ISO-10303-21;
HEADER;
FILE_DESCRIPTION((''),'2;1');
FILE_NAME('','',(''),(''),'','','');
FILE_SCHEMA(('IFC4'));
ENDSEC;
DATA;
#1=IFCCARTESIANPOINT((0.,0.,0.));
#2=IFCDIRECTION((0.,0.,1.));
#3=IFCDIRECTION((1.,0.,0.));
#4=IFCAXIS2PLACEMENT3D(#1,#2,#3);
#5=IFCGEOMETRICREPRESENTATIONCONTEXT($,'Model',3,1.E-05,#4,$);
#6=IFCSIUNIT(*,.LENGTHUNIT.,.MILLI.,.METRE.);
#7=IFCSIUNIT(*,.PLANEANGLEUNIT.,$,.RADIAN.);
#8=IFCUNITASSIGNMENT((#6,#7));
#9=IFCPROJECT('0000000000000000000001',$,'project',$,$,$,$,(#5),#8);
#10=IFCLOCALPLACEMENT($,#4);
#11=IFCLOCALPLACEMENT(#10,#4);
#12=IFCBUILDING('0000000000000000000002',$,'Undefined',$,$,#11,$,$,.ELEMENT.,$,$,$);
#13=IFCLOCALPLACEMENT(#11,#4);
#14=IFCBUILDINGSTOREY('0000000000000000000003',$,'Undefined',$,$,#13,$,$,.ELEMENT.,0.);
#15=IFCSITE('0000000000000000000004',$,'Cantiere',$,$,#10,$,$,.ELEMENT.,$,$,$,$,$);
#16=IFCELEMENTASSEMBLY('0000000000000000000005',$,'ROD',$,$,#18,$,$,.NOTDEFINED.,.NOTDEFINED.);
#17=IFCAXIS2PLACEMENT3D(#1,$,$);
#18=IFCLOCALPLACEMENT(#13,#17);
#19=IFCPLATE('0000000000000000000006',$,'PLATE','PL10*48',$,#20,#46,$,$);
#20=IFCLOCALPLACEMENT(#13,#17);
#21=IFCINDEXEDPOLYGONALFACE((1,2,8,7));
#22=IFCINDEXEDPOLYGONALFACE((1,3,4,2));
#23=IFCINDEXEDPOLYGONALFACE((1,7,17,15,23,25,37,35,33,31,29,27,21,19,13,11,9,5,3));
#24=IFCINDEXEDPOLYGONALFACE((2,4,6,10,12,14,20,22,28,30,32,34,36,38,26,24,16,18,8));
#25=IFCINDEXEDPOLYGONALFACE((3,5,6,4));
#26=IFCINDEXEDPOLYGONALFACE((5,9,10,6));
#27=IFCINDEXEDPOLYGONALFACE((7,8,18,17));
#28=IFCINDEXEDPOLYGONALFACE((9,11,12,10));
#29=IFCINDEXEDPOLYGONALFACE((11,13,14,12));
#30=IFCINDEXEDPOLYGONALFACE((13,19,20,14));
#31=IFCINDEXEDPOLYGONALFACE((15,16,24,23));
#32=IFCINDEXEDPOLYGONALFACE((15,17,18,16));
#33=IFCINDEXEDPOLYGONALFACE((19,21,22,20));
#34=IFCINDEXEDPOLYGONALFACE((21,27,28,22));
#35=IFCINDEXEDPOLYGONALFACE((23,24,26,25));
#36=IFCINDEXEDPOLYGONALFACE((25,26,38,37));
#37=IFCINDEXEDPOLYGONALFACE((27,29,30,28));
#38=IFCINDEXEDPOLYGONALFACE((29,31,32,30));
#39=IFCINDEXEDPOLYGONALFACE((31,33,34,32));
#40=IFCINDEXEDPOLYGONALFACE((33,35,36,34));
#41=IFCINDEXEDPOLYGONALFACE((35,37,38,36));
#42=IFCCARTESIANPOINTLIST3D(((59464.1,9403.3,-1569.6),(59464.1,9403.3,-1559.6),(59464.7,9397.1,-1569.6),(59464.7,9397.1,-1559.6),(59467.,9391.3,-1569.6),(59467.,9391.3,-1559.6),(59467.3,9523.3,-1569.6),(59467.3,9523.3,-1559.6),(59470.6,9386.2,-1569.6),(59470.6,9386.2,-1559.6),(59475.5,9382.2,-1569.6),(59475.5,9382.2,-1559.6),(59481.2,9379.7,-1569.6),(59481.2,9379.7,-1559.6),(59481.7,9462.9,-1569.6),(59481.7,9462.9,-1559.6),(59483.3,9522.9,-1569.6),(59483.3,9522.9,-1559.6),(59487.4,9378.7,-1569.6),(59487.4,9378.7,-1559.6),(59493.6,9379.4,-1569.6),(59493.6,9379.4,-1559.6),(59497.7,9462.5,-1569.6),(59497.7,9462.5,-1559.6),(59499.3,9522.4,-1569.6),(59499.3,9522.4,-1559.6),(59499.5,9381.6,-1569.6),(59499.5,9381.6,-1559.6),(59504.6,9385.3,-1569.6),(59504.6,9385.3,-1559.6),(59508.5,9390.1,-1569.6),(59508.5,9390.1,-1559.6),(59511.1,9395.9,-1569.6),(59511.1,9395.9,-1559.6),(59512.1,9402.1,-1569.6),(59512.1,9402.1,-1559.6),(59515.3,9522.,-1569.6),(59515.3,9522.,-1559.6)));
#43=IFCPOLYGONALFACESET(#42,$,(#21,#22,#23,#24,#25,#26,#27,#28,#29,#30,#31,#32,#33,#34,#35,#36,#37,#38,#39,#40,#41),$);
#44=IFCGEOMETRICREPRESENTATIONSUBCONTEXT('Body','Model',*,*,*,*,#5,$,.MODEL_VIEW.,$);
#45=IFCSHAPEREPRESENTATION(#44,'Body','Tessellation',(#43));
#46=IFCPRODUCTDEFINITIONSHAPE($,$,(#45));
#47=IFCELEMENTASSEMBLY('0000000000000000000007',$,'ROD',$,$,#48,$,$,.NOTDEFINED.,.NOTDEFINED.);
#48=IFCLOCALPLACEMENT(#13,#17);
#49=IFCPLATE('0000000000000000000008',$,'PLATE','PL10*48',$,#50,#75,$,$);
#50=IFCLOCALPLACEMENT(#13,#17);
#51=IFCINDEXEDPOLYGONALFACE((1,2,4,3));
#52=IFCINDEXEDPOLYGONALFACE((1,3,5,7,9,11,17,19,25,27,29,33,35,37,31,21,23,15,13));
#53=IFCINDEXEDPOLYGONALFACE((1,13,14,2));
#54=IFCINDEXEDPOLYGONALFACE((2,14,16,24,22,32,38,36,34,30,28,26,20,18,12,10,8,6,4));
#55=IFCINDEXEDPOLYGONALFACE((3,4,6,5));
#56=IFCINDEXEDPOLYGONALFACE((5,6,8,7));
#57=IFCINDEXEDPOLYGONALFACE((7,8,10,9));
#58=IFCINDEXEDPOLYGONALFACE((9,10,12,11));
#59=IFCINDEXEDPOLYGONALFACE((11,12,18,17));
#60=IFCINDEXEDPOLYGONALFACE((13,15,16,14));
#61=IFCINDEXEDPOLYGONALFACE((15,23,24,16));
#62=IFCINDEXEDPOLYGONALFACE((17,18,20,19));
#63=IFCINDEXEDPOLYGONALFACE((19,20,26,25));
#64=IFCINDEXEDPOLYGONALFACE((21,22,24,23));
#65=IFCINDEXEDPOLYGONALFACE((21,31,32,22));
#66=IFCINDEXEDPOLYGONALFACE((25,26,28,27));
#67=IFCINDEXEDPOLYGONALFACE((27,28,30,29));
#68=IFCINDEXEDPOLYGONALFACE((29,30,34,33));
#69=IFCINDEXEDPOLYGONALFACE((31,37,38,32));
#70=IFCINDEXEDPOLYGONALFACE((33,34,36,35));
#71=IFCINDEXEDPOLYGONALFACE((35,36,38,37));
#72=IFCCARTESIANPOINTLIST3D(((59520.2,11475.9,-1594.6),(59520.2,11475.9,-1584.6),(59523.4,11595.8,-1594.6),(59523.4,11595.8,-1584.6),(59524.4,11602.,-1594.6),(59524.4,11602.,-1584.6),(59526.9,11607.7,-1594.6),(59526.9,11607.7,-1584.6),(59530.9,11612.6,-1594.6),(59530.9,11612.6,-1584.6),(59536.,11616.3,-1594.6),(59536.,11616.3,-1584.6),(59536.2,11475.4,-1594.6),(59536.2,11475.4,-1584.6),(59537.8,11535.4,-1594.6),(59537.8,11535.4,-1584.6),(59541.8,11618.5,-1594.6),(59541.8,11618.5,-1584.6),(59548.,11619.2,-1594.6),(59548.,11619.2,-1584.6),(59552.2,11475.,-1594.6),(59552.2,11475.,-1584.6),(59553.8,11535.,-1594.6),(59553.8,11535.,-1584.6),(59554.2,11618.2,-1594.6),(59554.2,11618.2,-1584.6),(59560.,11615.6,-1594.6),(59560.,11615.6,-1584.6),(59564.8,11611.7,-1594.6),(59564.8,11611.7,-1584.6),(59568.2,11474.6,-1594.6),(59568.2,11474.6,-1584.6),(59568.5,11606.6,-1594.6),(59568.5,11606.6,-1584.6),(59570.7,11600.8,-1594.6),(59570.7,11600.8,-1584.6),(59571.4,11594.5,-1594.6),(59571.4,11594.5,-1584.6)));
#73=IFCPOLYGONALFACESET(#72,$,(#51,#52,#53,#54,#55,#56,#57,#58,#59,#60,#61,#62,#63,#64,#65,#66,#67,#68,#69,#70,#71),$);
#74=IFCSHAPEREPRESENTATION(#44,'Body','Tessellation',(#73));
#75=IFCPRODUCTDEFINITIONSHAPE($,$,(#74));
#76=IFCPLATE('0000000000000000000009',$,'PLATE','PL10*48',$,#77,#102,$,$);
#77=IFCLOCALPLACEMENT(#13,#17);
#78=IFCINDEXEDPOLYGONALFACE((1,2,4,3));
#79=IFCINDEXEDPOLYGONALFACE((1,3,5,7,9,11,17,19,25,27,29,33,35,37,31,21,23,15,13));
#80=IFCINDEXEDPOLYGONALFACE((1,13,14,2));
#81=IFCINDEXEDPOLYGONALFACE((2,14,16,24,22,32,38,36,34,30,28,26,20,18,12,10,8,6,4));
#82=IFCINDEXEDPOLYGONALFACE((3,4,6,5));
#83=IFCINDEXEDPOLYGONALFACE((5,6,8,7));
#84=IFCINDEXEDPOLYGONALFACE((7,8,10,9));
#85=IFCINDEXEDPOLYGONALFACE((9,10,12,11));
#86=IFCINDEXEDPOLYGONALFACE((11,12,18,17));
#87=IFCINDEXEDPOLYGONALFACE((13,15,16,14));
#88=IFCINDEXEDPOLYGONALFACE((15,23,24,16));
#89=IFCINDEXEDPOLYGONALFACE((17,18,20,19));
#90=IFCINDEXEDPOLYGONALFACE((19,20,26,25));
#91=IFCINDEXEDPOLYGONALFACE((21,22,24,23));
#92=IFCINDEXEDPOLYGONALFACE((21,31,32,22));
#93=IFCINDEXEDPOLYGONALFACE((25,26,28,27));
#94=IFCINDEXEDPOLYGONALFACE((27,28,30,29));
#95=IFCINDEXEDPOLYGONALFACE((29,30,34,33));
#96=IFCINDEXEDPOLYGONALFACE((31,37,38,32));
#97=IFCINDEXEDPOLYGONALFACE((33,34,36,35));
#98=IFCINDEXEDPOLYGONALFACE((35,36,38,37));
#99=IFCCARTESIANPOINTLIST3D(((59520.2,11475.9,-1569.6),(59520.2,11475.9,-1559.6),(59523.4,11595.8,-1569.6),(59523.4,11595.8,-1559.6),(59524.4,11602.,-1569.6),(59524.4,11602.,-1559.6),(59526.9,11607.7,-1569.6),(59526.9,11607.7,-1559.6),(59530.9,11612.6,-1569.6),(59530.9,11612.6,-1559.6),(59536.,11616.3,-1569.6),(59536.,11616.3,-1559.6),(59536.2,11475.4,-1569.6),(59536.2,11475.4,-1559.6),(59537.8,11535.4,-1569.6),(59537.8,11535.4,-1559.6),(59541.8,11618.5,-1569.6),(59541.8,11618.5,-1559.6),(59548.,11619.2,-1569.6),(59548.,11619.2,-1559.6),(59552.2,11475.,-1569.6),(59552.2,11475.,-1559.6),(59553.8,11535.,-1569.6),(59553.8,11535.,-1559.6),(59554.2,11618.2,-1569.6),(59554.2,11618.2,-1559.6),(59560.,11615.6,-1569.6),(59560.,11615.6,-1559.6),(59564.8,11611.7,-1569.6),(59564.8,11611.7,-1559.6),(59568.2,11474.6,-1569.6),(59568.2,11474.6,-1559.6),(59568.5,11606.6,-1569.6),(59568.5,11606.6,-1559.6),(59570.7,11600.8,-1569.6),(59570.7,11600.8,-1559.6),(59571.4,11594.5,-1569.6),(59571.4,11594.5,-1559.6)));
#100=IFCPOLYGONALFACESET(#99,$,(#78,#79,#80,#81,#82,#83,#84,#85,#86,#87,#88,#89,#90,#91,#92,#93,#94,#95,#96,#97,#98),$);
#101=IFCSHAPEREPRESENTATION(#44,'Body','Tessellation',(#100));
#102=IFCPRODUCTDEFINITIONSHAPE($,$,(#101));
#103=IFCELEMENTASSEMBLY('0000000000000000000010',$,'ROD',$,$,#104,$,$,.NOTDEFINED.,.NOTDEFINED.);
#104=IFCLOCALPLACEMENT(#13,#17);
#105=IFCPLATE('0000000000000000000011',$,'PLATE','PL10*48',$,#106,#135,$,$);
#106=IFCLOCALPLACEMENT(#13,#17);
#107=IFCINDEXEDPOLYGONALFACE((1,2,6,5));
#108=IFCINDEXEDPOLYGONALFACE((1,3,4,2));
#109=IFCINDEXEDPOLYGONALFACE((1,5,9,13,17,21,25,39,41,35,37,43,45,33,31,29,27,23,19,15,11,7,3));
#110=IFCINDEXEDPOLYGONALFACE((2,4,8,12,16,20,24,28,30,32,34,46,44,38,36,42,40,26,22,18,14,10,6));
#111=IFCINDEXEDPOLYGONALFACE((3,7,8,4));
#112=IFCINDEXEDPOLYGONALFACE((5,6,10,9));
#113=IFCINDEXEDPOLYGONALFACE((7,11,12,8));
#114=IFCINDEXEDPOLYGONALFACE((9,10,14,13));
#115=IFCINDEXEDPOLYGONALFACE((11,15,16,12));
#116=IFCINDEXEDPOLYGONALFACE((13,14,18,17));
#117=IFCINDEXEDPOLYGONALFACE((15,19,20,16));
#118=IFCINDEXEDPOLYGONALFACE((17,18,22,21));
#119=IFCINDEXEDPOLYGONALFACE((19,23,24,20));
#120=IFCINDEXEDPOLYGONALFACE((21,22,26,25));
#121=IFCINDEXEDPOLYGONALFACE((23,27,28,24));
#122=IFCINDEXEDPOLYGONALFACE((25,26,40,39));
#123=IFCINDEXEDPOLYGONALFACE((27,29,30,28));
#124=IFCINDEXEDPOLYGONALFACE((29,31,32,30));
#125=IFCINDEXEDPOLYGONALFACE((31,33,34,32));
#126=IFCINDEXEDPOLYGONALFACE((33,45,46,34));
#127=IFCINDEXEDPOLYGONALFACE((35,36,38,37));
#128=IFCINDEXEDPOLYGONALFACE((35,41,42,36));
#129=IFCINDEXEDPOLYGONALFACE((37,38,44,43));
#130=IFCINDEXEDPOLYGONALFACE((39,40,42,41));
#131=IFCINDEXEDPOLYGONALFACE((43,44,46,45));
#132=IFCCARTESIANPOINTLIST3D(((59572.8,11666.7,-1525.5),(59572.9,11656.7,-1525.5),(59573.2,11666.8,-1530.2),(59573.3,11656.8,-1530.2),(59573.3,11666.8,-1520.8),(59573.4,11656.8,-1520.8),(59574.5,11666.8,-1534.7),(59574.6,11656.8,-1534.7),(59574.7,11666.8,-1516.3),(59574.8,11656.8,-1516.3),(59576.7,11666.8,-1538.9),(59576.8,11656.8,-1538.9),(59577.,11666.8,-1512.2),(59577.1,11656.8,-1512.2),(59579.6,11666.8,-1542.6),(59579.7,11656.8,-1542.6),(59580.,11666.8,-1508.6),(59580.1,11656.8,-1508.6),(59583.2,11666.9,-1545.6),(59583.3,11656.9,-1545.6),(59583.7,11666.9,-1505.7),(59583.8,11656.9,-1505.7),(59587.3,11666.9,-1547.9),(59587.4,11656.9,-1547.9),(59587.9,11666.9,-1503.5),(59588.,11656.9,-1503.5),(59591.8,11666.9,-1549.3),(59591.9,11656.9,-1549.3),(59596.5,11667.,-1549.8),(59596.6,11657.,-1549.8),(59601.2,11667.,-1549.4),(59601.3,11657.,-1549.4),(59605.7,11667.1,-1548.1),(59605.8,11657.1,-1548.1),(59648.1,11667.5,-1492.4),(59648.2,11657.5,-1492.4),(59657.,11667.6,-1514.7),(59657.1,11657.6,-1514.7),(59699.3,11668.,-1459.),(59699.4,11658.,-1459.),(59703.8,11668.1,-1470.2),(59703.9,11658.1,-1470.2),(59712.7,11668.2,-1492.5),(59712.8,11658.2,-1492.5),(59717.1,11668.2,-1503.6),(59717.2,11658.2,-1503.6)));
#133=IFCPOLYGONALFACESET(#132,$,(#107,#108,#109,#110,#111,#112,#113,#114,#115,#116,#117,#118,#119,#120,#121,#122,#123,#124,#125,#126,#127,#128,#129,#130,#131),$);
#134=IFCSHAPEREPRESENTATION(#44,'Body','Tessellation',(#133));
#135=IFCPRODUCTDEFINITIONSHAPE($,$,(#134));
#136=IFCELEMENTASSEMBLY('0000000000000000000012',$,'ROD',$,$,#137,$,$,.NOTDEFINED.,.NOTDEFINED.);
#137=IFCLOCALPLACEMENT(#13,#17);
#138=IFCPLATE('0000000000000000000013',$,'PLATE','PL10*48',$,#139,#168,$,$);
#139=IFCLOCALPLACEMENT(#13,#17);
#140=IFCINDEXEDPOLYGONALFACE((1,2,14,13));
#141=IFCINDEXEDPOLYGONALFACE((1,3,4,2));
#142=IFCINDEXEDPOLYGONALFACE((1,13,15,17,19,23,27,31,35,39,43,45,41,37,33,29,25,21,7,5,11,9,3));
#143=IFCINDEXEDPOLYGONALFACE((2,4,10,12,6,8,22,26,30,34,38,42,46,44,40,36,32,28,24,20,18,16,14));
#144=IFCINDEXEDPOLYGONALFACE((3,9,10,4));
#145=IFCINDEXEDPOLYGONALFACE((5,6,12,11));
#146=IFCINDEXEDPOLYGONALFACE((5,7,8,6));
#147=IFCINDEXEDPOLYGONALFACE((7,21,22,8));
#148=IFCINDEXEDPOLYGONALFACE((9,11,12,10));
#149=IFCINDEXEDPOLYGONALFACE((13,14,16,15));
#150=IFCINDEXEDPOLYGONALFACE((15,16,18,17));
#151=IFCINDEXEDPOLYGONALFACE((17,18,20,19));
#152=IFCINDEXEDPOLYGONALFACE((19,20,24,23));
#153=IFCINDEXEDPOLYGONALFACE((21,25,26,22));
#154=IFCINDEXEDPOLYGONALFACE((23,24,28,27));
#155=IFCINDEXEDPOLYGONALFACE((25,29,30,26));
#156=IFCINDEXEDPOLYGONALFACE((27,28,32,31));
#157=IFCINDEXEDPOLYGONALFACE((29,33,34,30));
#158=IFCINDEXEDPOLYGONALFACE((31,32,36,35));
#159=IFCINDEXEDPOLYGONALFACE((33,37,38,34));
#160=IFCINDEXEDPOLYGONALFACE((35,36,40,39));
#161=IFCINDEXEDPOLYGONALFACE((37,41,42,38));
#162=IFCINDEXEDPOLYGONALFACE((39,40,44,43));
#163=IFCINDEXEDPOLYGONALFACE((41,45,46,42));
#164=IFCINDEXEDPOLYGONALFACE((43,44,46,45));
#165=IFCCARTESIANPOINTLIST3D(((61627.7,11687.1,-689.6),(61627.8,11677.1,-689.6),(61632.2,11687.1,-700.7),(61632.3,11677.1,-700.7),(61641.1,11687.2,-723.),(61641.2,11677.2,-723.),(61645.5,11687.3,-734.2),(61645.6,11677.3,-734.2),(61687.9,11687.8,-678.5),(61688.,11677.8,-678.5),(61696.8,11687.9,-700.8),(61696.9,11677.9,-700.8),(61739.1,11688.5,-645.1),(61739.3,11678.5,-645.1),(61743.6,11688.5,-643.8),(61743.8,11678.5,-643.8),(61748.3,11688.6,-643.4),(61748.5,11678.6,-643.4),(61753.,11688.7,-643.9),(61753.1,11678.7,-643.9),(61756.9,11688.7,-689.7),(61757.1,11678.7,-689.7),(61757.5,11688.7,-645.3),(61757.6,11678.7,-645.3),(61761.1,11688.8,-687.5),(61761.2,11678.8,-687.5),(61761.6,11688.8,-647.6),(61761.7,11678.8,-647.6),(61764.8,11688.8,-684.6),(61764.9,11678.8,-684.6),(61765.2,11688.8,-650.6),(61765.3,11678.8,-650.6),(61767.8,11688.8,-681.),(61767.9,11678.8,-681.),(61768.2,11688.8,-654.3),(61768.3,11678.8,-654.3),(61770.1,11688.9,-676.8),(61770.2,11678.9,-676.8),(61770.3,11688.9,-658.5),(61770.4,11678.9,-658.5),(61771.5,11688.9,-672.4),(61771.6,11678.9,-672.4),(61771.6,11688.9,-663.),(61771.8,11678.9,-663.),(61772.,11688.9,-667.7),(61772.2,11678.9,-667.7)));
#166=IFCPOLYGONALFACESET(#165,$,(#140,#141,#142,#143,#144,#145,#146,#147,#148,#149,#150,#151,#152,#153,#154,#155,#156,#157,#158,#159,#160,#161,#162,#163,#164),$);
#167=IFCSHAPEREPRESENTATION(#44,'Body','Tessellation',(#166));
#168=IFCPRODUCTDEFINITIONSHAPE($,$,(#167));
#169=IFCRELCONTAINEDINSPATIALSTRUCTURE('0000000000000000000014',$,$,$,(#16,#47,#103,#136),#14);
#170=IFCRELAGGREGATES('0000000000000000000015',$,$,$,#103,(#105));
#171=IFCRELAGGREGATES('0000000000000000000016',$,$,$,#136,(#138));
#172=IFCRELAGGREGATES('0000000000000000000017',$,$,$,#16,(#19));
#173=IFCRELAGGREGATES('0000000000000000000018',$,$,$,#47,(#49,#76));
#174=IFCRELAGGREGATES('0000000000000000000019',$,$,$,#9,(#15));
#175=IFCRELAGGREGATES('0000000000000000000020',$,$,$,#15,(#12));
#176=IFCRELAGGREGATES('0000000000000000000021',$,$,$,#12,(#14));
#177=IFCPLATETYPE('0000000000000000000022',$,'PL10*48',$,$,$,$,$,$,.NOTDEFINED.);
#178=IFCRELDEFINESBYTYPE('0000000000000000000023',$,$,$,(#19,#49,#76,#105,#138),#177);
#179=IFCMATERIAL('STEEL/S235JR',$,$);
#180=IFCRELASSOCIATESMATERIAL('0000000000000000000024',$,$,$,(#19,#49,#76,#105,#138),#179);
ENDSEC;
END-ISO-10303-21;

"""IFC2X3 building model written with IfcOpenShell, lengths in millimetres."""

from ifc_helpers import new_model, si_unit, frame, frame_2d, origin_with_axes, place, context, subcontext, project, spatial, polyline, circle_curve, parameter, trimmed, segment, composite_curve, outline, extrude, material, type_object, element, aggregate, save


model = new_model("IFC2X3")

# Units and contexts
model_context = context("Model", 3, precision=1e-05, world=origin_with_axes())
body_context = subcontext(model_context, "Body", "Model", "MODEL_VIEW")
ifc_project = project(units=[si_unit("LENGTHUNIT", "METRE", prefix="MILLI"), si_unit("PLANEANGLEUNIT", "RADIAN")], contexts=[model_context])

# Site, building, storey
site_placement = place(None, origin_with_axes())
site = spatial("IfcSite", under=ifc_project, at=site_placement, Name="Cantiere", CompositionType="ELEMENT")
building_placement = place(site_placement, origin_with_axes())
building = spatial("IfcBuilding", under=site, at=building_placement, Name="Undefined", CompositionType="ELEMENT")
storey_placement = place(building_placement, origin_with_axes())
storey = spatial("IfcBuildingStorey", under=building, at=storey_placement, Name="Undefined", CompositionType="ELEMENT", Elevation=0.0)

# Shared definitions
ifc_material_1 = material(Name="STEEL/S235JR")

# Element assemblies, plates
assembly_1_placement = place(storey_placement, origin_with_axes())
assembly_1 = element("IfcElementAssembly", 1, at=assembly_1_placement, inside=storey, Name="ROD", AssemblyPlace="NOTDEFINED", PredefinedType="NOTDEFINED")
plate_type_1 = type_object("IfcPlateType", Name="PL10*48", PredefinedType="NOTDEFINED")
plate_1_placement = place(assembly_1_placement, frame((59467.3, 9523.3, -1564.6), z_axis=(0.0, 0.0, 1.0), x_axis=(-0.026971, -0.999636, -0.000001)))
plate_1 = element("IfcPlate", 2, at=plate_1_placement, type_object=plate_type_1, material=ifc_material_1, Name="PLATE", Description="PL10*48", context=body_context, shape_type="SweptSolid", body=[
    extrude(outline(composite_curve([segment(polyline([(0.0, 0.0), (120.0, 0.0)]), True, "CONTINUOUS"), segment(trimmed(circle_curve(frame_2d((120.0, 24.0), x_axis=(0.0, -1.0)), 24.0), [parameter(0.0)], [parameter(1.570796)], True, "PARAMETER"), True, "CONTINUOUS"), segment(trimmed(circle_curve(frame_2d((120.0, 24.0), x_axis=(1.0, 0.0)), 24.0), [parameter(0.0)], [parameter(1.570796)], True, "PARAMETER"), True, "CONTINUOUS"), segment(polyline([(120.0, 48.0), (0.0, 48.0), (0.0, 32.0), (60.0, 32.0), (60.0, 16.0), (0.0, 16.0), (0.0, 0.0)]), True, "CONTINUOUS")], self_intersect=True)), frame((0.0, 0.0, -5.0), z_axis=(0.0, 0.0, 1.0), x_axis=(1.0, 0.0, 0.0)), (0.0, 0.0, 1.0), 10.0),
])
assembly_2_placement = place(storey_placement, origin_with_axes())
assembly_2 = element("IfcElementAssembly", 3, at=assembly_2_placement, inside=storey, Name="ROD", AssemblyPlace="NOTDEFINED", PredefinedType="NOTDEFINED")
plate_2_placement = place(assembly_2_placement, frame((59568.2, 11474.6, -1589.6), z_axis=(0.0, 0.0, 1.0), x_axis=(0.026971, 0.999636, 0.0)))
plate_2 = element("IfcPlate", 4, at=plate_2_placement, type_object=plate_type_1, material=ifc_material_1, Name="PLATE", Description="PL10*48", context=body_context, shape_type="SweptSolid", body=[
    extrude(outline(composite_curve([segment(polyline([(0.0, 0.0), (120.0, 0.0)]), True, "CONTINUOUS"), segment(trimmed(circle_curve(frame_2d((120.0, 24.0), x_axis=(0.0, -1.0)), 24.0), [parameter(0.0)], [parameter(1.570796)], True, "PARAMETER"), True, "CONTINUOUS"), segment(trimmed(circle_curve(frame_2d((120.0, 24.0), x_axis=(1.0, 0.0)), 24.0), [parameter(0.0)], [parameter(1.570796)], True, "PARAMETER"), True, "CONTINUOUS"), segment(polyline([(120.0, 48.0), (0.0, 48.0), (0.0, 32.0), (60.0, 32.0), (60.0, 16.0), (0.0, 16.0), (0.0, 0.0)]), True, "CONTINUOUS")], self_intersect=True)), frame((0.0, 0.0, -5.0), z_axis=(0.0, 0.0, 1.0), x_axis=(1.0, 0.0, 0.0)), (0.0, 0.0, 1.0), 10.0),
])
plate_3_placement = place(assembly_2_placement, frame((59568.2, 11474.6, -1564.6), z_axis=(0.0, 0.0, 1.0), x_axis=(0.026971, 0.999636, 0.0)))
plate_3 = element("IfcPlate", 5, at=plate_3_placement, type_object=plate_type_1, material=ifc_material_1, Name="PLATE", Description="PL10*48", context=body_context, shape_type="SweptSolid", body=[
    extrude(outline(composite_curve([segment(polyline([(0.0, 0.0), (120.0, 0.0)]), True, "CONTINUOUS"), segment(trimmed(circle_curve(frame_2d((120.0, 24.0), x_axis=(0.0, -1.0)), 24.0), [parameter(0.0)], [parameter(1.570796)], True, "PARAMETER"), True, "CONTINUOUS"), segment(trimmed(circle_curve(frame_2d((120.0, 24.0), x_axis=(1.0, 0.0)), 24.0), [parameter(0.0)], [parameter(1.570796)], True, "PARAMETER"), True, "CONTINUOUS"), segment(polyline([(120.0, 48.0), (0.0, 48.0), (0.0, 32.0), (60.0, 32.0), (60.0, 16.0), (0.0, 16.0), (0.0, 0.0)]), True, "CONTINUOUS")], self_intersect=True)), frame((0.0, 0.0, -5.0), z_axis=(0.0, 0.0, 1.0), x_axis=(1.0, 0.0, 0.0)), (0.0, 0.0, 1.0), 10.0),
])

# Element assemblies, plates
assembly_3_placement = place(storey_placement, origin_with_axes())
assembly_3 = element("IfcElementAssembly", 6, at=assembly_3_placement, inside=storey, Name="ROD", AssemblyPlace="NOTDEFINED", PredefinedType="NOTDEFINED")
plate_4_placement = place(assembly_3_placement, frame((59699.4, 11663.0, -1459.0), z_axis=(0.010138, -0.999949, 0.0), x_axis=(-0.92874, -0.009416, -0.370611)))
plate_4 = element("IfcPlate", 7, at=plate_4_placement, type_object=plate_type_1, material=ifc_material_1, Name="PLATE", Description="PL10*48", context=body_context, shape_type="SweptSolid", body=[
    extrude(outline(polyline([(0.0, 0.0), (120.0, 0.0), (124.7, 0.5), (129.2, 1.8), (133.3, 4.0), (137.0, 7.0), (140.0, 10.7), (142.2, 14.8), (143.5, 19.3), (144.0, 24.0), (144.0, 24.0), (143.5, 28.7), (142.2, 33.2), (140.0, 37.3), (137.0, 41.0), (133.3, 44.0), (129.2, 46.2), (124.7, 47.5), (120.0, 48.0), (0.0, 48.0), (0.0, 36.0), (60.0, 36.0), (60.0, 12.0), (0.0, 12.0), (0.0, 0.0)])), frame((0.0, 0.0, -5.0), z_axis=(0.0, 0.0, 1.0), x_axis=(1.0, 0.0, 0.0)), (0.0, 0.0, 1.0), 10.0),
])
aggregate(assembly_3, [plate_4])
assembly_4_placement = place(storey_placement, origin_with_axes())
assembly_4 = element("IfcElementAssembly", 8, at=assembly_4_placement, inside=storey, Name="ROD", AssemblyPlace="NOTDEFINED", PredefinedType="NOTDEFINED")
plate_5_placement = place(assembly_4_placement, frame((61627.8, 11682.1, -689.6), z_axis=(-0.012617, 0.99992, -0.000014), x_axis=(0.928585, 0.011722, 0.370936)))
plate_5 = element("IfcPlate", 9, at=plate_5_placement, type_object=plate_type_1, material=ifc_material_1, Name="PLATE", Description="PL10*48", context=body_context, shape_type="SweptSolid", body=[
    extrude(outline(polyline([(0.0, 0.0), (120.0, 0.0), (124.7, 0.5), (129.2, 1.8), (133.3, 4.0), (137.0, 7.0), (140.0, 10.7), (142.2, 14.8), (143.5, 19.3), (144.0, 24.0), (144.0, 24.0), (143.5, 28.7), (142.2, 33.2), (140.0, 37.3), (137.0, 41.0), (133.3, 44.0), (129.2, 46.2), (124.7, 47.5), (120.0, 48.0), (0.0, 48.0), (0.0, 36.0), (60.0, 36.0), (60.0, 12.0), (0.0, 12.0), (0.0, 0.0)])), frame((0.0, 0.0, -5.0), z_axis=(0.0, 0.0, 1.0), x_axis=(1.0, 0.0, 0.0)), (0.0, 0.0, 1.0), 10.0),
])
aggregate(assembly_4, [plate_5])

aggregate(assembly_1, [plate_1])
aggregate(assembly_2, [plate_2, plate_3])

save(model, "model.ifc")
